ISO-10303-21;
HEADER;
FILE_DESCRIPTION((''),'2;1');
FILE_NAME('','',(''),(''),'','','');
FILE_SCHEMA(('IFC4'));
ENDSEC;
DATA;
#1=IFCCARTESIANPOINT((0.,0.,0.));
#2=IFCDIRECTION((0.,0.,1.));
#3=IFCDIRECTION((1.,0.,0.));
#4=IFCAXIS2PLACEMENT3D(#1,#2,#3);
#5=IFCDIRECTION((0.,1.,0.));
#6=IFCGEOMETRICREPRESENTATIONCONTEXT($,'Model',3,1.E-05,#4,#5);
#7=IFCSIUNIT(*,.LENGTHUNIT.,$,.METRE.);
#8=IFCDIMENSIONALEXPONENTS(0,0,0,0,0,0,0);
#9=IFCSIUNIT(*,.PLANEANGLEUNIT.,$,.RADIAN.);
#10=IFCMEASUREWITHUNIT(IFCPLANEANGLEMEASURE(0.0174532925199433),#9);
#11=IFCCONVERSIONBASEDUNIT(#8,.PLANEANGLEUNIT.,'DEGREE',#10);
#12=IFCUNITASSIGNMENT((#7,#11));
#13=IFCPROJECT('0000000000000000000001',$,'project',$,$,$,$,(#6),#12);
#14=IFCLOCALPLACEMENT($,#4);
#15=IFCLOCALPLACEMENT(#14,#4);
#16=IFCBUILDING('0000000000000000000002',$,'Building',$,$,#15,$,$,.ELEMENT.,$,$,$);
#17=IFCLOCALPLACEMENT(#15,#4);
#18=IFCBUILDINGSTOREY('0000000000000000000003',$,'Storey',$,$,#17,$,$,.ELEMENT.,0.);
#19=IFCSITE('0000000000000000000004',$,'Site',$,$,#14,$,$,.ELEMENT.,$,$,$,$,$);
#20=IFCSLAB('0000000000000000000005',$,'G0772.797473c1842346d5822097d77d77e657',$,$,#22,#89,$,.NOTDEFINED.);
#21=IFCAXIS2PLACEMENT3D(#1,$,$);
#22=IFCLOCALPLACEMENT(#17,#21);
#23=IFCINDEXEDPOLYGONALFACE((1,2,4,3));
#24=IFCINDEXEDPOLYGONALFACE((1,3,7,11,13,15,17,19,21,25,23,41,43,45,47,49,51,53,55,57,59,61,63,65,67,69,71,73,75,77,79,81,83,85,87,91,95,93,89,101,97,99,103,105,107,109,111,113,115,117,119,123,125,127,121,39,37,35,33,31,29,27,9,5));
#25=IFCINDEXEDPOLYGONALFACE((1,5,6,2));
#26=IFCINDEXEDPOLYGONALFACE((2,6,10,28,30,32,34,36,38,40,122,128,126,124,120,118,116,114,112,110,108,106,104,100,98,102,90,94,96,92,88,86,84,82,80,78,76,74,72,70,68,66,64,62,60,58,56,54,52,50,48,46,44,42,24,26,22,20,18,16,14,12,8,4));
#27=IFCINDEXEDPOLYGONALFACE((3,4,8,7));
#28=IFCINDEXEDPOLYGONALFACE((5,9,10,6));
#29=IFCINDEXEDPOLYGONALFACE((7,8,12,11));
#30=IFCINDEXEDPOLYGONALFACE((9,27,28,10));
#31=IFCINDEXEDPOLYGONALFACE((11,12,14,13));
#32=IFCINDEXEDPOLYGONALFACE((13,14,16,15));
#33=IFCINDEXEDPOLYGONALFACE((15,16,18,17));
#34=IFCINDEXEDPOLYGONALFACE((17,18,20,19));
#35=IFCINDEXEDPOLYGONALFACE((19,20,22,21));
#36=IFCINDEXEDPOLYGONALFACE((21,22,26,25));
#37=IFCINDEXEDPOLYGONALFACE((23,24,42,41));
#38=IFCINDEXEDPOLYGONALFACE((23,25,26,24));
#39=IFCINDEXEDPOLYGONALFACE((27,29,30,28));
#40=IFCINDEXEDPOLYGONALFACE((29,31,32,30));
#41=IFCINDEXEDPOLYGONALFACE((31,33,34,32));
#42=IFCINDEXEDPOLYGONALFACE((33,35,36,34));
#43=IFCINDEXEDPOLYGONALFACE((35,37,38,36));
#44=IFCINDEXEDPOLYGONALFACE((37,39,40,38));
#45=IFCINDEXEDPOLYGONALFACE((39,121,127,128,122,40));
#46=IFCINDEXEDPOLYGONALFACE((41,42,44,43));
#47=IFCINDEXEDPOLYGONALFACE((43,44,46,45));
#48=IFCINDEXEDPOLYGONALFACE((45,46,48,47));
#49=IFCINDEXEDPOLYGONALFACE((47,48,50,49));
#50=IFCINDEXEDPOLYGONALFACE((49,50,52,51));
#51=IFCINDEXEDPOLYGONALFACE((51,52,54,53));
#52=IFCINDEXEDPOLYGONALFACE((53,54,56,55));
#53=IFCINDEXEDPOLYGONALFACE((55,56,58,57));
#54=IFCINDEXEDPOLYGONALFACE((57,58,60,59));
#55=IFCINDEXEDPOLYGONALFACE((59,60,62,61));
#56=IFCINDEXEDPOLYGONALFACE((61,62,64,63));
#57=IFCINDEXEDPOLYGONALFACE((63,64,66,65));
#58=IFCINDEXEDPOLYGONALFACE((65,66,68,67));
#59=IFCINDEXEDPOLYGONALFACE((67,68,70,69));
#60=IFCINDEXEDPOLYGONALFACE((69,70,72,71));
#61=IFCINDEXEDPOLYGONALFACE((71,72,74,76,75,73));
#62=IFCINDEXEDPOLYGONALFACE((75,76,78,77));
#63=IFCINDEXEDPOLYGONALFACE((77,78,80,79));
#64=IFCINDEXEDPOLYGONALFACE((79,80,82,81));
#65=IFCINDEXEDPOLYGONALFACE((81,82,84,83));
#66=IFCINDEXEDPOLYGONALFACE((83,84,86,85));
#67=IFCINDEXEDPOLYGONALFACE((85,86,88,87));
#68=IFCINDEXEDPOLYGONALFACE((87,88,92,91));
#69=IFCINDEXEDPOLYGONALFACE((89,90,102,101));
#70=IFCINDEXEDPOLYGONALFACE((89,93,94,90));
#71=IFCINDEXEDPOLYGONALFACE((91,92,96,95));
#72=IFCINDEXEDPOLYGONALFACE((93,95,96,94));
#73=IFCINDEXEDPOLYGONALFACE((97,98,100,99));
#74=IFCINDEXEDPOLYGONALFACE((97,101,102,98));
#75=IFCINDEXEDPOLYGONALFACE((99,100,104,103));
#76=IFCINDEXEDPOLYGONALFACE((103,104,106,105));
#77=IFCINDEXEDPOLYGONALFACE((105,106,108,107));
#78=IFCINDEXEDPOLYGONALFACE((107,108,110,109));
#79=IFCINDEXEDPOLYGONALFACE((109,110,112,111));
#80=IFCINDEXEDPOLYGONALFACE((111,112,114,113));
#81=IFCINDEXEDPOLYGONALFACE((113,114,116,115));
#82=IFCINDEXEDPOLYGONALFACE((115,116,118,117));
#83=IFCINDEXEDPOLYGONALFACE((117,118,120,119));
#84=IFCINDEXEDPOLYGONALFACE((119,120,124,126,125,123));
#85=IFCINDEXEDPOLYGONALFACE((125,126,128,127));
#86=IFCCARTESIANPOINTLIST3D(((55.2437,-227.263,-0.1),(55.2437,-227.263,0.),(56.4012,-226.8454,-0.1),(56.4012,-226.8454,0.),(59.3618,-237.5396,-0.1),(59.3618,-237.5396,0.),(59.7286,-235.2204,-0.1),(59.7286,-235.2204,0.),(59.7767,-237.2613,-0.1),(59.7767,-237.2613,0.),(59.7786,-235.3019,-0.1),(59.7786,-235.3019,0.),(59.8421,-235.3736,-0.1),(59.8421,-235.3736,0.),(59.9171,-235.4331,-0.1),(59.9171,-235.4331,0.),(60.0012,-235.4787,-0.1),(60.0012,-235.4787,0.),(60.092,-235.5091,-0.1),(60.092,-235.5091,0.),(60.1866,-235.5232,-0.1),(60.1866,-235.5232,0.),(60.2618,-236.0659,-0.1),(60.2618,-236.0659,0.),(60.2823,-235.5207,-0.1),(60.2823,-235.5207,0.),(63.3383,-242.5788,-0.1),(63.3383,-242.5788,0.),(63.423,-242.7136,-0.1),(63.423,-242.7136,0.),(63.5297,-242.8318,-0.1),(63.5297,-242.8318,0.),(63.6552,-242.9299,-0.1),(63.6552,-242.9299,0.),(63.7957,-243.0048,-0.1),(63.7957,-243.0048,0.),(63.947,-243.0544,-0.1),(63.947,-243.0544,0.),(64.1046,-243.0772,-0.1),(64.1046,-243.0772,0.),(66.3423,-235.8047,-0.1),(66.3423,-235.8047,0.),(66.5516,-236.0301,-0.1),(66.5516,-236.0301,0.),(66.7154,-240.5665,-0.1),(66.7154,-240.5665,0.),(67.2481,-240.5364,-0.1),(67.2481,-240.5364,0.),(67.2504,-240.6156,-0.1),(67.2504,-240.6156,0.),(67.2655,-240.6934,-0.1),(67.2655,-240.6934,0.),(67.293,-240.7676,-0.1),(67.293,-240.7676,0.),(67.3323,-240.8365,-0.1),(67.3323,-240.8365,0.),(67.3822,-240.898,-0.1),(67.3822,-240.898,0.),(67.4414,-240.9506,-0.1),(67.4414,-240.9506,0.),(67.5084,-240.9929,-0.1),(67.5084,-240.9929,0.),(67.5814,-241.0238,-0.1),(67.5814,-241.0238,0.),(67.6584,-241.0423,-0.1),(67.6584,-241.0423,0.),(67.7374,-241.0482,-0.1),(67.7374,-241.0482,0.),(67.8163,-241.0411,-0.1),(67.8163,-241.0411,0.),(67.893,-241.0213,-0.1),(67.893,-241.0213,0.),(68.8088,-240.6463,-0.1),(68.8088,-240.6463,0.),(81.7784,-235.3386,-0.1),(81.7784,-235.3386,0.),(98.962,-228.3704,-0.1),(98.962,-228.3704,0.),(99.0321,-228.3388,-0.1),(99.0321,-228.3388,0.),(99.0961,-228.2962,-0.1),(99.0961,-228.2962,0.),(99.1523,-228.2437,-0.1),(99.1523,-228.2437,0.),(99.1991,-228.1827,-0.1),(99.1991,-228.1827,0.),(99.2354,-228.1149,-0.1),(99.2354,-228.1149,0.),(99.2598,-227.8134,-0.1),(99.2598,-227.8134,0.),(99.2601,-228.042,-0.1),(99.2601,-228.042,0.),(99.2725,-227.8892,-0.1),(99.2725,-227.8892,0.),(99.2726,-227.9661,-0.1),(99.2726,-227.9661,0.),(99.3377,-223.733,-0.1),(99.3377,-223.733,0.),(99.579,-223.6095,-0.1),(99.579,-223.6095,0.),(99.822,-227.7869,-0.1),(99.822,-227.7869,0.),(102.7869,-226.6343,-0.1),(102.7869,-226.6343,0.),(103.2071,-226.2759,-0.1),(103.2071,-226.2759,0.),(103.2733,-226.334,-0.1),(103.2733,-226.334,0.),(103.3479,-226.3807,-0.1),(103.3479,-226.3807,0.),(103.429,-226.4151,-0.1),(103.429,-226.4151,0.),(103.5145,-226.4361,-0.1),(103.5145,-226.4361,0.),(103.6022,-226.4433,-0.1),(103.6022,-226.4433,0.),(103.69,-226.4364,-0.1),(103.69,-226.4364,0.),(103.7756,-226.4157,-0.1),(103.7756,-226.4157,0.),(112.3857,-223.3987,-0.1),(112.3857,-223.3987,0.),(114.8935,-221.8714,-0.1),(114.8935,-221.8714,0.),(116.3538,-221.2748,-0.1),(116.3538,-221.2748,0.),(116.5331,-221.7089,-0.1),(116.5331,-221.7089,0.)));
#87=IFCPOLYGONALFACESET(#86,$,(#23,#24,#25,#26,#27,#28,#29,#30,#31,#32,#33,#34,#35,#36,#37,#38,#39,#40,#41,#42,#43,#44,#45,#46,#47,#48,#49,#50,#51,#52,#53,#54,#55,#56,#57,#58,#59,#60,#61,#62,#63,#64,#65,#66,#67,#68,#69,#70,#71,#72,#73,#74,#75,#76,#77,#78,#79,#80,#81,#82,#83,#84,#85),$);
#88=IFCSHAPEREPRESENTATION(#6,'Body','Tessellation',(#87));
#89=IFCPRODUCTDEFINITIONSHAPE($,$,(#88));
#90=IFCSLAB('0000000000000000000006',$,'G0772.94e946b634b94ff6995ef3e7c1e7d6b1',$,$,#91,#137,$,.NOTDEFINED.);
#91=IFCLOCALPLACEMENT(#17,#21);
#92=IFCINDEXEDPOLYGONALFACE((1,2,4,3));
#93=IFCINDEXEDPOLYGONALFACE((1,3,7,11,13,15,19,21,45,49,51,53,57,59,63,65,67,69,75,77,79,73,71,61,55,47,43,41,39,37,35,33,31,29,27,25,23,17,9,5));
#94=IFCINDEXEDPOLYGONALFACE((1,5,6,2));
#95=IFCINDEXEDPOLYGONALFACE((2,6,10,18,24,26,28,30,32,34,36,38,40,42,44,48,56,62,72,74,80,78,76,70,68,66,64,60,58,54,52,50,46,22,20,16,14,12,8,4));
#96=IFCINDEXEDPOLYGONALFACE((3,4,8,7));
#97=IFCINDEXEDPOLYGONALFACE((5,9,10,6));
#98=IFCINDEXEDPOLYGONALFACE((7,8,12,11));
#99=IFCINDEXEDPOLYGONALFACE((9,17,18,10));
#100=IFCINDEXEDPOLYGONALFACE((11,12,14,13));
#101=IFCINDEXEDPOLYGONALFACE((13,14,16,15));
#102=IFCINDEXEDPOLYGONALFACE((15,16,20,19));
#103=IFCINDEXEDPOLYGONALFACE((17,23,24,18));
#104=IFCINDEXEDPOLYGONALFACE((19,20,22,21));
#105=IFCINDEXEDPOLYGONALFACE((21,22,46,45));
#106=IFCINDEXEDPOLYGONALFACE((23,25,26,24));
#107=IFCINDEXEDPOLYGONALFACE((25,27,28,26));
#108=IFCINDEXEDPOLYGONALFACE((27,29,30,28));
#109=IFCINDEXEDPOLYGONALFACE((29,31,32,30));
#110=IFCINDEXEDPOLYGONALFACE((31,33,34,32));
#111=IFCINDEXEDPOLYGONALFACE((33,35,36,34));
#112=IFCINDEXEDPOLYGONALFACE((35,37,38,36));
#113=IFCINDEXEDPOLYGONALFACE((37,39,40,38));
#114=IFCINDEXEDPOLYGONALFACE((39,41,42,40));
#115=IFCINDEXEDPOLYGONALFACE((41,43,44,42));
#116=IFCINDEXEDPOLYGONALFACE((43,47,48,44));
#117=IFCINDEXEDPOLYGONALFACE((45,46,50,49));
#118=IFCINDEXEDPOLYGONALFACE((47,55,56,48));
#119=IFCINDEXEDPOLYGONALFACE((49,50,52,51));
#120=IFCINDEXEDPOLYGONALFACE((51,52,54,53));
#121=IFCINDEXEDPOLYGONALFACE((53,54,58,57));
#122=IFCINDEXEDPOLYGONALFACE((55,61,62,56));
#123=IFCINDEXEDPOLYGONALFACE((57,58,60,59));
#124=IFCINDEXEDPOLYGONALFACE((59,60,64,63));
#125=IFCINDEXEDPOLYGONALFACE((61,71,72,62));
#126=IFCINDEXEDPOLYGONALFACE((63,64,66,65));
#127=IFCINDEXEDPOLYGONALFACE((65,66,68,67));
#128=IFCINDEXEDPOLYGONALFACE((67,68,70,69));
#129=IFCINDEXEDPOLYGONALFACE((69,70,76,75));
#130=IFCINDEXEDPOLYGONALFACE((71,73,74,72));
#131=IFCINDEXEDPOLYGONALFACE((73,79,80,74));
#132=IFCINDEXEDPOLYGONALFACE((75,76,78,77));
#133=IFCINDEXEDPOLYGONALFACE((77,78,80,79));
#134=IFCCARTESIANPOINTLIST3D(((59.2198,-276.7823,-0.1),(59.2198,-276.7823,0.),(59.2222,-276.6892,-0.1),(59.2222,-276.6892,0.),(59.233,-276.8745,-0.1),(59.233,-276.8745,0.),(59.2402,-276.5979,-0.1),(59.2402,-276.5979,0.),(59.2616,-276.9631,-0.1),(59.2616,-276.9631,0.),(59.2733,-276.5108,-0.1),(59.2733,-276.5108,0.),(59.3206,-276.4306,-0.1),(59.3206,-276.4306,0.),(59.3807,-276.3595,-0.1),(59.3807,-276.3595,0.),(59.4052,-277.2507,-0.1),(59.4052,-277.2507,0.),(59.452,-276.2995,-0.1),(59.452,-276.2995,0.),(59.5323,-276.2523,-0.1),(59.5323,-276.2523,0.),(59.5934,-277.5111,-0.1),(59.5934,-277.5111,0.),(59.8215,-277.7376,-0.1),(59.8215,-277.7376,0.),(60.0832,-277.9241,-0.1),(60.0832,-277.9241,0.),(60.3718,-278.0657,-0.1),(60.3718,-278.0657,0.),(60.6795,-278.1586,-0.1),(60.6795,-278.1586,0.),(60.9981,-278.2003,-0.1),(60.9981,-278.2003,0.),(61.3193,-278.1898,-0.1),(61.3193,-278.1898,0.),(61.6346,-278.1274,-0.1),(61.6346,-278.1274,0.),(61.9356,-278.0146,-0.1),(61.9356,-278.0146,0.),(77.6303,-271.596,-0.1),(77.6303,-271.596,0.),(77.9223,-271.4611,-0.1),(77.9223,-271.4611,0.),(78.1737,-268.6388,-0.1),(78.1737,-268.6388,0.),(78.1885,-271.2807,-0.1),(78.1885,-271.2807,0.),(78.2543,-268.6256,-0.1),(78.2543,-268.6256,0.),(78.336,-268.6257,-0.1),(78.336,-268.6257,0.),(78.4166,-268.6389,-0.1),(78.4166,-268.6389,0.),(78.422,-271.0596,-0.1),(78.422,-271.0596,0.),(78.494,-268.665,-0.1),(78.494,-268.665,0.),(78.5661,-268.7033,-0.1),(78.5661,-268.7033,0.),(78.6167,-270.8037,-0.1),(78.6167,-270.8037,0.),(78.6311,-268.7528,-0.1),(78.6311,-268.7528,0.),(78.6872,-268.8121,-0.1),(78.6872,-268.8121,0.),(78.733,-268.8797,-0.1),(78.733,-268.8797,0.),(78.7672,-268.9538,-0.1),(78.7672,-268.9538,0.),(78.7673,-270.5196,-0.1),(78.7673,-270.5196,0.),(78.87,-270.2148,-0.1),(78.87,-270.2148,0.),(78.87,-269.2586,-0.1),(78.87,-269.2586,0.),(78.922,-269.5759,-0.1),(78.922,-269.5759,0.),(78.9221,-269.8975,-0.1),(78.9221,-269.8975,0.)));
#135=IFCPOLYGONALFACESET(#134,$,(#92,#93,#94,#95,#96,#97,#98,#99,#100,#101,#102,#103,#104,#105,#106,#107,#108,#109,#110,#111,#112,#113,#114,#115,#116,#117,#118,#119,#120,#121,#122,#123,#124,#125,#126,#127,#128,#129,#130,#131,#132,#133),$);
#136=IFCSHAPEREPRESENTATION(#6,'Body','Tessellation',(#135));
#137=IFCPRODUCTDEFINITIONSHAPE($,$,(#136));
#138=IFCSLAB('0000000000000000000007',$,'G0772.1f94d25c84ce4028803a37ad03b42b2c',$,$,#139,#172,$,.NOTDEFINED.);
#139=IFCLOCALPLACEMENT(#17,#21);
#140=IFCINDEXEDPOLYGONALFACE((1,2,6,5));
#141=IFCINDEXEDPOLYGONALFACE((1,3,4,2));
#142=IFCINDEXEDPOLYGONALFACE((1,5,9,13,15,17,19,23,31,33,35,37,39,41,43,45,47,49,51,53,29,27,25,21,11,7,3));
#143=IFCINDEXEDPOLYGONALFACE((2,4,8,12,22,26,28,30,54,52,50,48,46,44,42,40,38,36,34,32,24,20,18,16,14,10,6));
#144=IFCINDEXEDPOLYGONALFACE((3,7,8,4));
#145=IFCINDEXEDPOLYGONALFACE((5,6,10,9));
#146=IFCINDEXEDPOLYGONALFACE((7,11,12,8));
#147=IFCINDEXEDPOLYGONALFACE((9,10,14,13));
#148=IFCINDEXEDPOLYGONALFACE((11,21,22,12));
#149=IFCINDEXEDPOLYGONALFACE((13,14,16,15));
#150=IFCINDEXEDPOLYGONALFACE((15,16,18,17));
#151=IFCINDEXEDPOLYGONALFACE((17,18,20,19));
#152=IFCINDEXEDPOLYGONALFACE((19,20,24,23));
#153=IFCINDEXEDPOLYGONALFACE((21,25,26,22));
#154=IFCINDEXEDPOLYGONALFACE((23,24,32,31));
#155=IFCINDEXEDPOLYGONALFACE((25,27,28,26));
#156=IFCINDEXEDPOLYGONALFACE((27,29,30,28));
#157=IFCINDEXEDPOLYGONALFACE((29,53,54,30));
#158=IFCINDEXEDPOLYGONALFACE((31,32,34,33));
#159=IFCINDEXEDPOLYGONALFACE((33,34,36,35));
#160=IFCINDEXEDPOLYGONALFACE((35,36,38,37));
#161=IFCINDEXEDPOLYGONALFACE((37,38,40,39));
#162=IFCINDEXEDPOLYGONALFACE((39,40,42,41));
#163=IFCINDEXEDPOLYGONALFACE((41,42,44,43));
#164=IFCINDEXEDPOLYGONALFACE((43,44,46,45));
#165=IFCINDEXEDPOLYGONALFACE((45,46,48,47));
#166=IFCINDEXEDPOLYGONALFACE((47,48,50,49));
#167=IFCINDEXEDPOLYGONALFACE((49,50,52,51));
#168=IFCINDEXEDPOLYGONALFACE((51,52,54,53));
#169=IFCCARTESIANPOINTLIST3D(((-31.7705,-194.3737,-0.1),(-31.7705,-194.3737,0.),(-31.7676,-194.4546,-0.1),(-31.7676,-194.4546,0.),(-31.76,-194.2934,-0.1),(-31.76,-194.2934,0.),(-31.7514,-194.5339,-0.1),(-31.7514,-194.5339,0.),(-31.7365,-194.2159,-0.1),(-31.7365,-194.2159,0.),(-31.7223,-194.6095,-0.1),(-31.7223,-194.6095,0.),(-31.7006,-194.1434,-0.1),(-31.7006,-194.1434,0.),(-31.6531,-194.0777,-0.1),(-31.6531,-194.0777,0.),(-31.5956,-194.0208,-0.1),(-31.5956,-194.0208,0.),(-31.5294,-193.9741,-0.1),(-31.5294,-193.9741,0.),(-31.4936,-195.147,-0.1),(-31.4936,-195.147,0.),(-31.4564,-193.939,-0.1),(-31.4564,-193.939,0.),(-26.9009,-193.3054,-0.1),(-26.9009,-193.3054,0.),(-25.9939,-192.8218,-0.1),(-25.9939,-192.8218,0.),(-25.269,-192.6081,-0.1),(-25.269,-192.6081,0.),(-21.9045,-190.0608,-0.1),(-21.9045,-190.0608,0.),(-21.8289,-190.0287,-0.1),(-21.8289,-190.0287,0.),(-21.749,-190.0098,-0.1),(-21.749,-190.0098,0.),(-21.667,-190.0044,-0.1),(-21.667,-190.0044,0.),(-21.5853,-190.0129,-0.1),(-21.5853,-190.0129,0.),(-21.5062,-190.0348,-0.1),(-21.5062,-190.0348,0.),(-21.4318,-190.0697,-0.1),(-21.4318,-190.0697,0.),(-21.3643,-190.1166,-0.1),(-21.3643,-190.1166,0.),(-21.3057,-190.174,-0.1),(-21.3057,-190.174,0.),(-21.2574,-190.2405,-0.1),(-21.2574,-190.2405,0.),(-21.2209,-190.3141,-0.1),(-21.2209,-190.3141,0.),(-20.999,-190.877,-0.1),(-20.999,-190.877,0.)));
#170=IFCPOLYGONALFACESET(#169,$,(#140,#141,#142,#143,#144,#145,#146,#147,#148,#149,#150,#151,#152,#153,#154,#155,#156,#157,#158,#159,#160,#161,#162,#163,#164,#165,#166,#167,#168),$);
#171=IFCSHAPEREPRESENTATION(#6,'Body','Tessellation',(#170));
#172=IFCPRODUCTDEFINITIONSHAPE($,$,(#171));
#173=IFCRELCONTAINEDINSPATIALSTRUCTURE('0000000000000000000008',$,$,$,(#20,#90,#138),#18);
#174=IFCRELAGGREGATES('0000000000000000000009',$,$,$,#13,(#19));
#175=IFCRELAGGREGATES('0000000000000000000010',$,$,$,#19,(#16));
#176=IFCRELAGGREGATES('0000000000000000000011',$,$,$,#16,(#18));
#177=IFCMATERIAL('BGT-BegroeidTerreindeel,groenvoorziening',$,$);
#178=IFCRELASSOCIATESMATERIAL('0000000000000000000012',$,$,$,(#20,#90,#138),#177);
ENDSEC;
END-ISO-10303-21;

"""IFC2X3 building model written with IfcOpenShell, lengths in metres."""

from ifc_helpers import new_model, entity, si_unit, converted_unit, direction, frame, origin_with_axes, place, context, project, spatial, polyline, outline, extrude, material, element, save


model = new_model("IFC2X3")

# Units and contexts
model_context = context("Model", 3, precision=1e-05, world=origin_with_axes(), true_north=direction((0.0, 1.0, 0.0)))
ifc_project = project(units=[si_unit("LENGTHUNIT", "METRE"), converted_unit("PLANEANGLEUNIT", "DEGREE", entity("IfcPlaneAngleMeasure", 0.0174532925199433), si_unit("PLANEANGLEUNIT", "RADIAN"), dimensions=[0, 0, 0, 0, 0, 0, 0])], contexts=[model_context])

# Site, building, storey
site_placement = place(None, origin_with_axes())
site = spatial("IfcSite", under=ifc_project, at=site_placement, Name="Site", CompositionType="ELEMENT")
building_placement = place(site_placement, origin_with_axes())
building = spatial("IfcBuilding", under=site, at=building_placement, Name="Building", CompositionType="ELEMENT")
storey_placement = place(building_placement, origin_with_axes())
storey = spatial("IfcBuildingStorey", under=building, at=storey_placement, Name="Storey", CompositionType="ELEMENT", Elevation=0.0)

# Slabs
ifc_material_1 = material(Name="BGT-BegroeidTerreindeel,groenvoorziening")
slab_1_placement = place(storey_placement, frame((0.0, 0.0, -0.1), z_axis=(0.0, 0.0, 1.0), x_axis=(1.0, 0.0, 0.0)))
element("IfcSlab", 1, at=slab_1_placement, inside=storey, material=ifc_material_1, Name="G0772.797473c1842346d5822097d77d77e657", PredefinedType="NOTDEFINED", context=model_context, shape_type="SweptSolid", body=[
    extrude(outline(polyline([(102.7869, -226.6343), (103.2071, -226.2759), (103.2733, -226.334), (103.3479, -226.3807), (103.429, -226.4151), (103.5145, -226.4361), (103.6022, -226.4433), (103.69, -226.4364), (103.7756, -226.4157), (114.8935, -221.8714), (116.3538, -221.2748), (116.5331, -221.7089), (112.3857, -223.3987), (64.1046, -243.0772), (63.947, -243.0544), (63.7957, -243.0048), (63.6552, -242.9299), (63.5297, -242.8318), (63.423, -242.7136), (63.3383, -242.5788), (59.7767, -237.2613), (59.3618, -237.5396), (55.2437, -227.263), (56.4012, -226.8454), (59.7286, -235.2204), (59.7786, -235.3019), (59.8421, -235.3736), (59.9171, -235.4331), (60.0012, -235.4787), (60.092, -235.5091), (60.1866, -235.5232), (60.2823, -235.5207), (60.2618, -236.0659), (66.3423, -235.8047), (66.5516, -236.0301), (66.7154, -240.5665), (67.2481, -240.5364), (67.2504, -240.6156), (67.2655, -240.6934), (67.293, -240.7676), (67.3323, -240.8365), (67.3822, -240.898), (67.4414, -240.9506), (67.5084, -240.9929), (67.5814, -241.0238), (67.6584, -241.0423), (67.7374, -241.0482), (67.8163, -241.0411), (67.893, -241.0213), (68.8088, -240.6463), (81.7784, -235.3386), (98.962, -228.3704), (99.0321, -228.3388), (99.0961, -228.2962), (99.1523, -228.2437), (99.1991, -228.1827), (99.2354, -228.1149), (99.2601, -228.042), (99.2726, -227.9661), (99.2725, -227.8892), (99.2598, -227.8134), (99.822, -227.7869), (99.3377, -223.733), (99.579, -223.6095), (102.7869, -226.6343)])), origin_with_axes(), (0.0, 0.0, 1.0), 0.1),
])
slab_2_placement = place(storey_placement, frame((0.0, 0.0, -0.1), z_axis=(0.0, 0.0, 1.0), x_axis=(1.0, 0.0, 0.0)))
element("IfcSlab", 2, at=slab_2_placement, inside=storey, material=ifc_material_1, Name="G0772.94e946b634b94ff6995ef3e7c1e7d6b1", PredefinedType="NOTDEFINED", context=model_context, shape_type="SweptSolid", body=[
    extrude(outline(polyline([(78.1737, -268.6388), (78.2543, -268.6256), (78.336, -268.6257), (78.4166, -268.6389), (78.494, -268.665), (78.5661, -268.7033), (78.6311, -268.7528), (78.6872, -268.8121), (78.733, -268.8797), (78.7672, -268.9538), (78.87, -269.2586), (78.922, -269.5759), (78.9221, -269.8975), (78.87, -270.2148), (78.7673, -270.5196), (78.6167, -270.8037), (78.422, -271.0596), (78.1885, -271.2807), (77.9223, -271.4611), (77.6303, -271.596), (61.9356, -278.0146), (61.6346, -278.1274), (61.3193, -278.1898), (60.9981, -278.2003), (60.6795, -278.1586), (60.3718, -278.0657), (60.0832, -277.9241), (59.8215, -277.7376), (59.5934, -277.5111), (59.4052, -277.2507), (59.2616, -276.9631), (59.233, -276.8745), (59.2198, -276.7823), (59.2222, -276.6892), (59.2402, -276.5979), (59.2733, -276.5108), (59.3206, -276.4306), (59.3807, -276.3595), (59.452, -276.2995), (59.5323, -276.2523), (78.1737, -268.6388)])), origin_with_axes(), (0.0, 0.0, 1.0), 0.1),
])
slab_3_placement = place(storey_placement, frame((0.0, 0.0, -0.1), z_axis=(0.0, 0.0, 1.0), x_axis=(1.0, 0.0, 0.0)))
element("IfcSlab", 3, at=slab_3_placement, inside=storey, material=ifc_material_1, Name="G0772.1f94d25c84ce4028803a37ad03b42b2c", PredefinedType="NOTDEFINED", context=model_context, shape_type="SweptSolid", body=[
    extrude(outline(polyline([(-21.9045, -190.0608), (-21.8289, -190.0287), (-21.749, -190.0098), (-21.667, -190.0044), (-21.5853, -190.0129), (-21.5062, -190.0348), (-21.4318, -190.0697), (-21.3643, -190.1166), (-21.3057, -190.174), (-21.2574, -190.2405), (-21.2209, -190.3141), (-20.999, -190.877), (-25.269, -192.6081), (-25.9939, -192.8218), (-26.9009, -193.3054), (-31.4936, -195.147), (-31.7223, -194.6095), (-31.7514, -194.5339), (-31.7676, -194.4546), (-31.7705, -194.3737), (-31.76, -194.2934), (-31.7365, -194.2159), (-31.7006, -194.1434), (-31.6531, -194.0777), (-31.5956, -194.0208), (-31.5294, -193.9741), (-31.4564, -193.939), (-21.9045, -190.0608)])), origin_with_axes(), (0.0, 0.0, 1.0), 0.1),
])

save(model, "model.ifc")
